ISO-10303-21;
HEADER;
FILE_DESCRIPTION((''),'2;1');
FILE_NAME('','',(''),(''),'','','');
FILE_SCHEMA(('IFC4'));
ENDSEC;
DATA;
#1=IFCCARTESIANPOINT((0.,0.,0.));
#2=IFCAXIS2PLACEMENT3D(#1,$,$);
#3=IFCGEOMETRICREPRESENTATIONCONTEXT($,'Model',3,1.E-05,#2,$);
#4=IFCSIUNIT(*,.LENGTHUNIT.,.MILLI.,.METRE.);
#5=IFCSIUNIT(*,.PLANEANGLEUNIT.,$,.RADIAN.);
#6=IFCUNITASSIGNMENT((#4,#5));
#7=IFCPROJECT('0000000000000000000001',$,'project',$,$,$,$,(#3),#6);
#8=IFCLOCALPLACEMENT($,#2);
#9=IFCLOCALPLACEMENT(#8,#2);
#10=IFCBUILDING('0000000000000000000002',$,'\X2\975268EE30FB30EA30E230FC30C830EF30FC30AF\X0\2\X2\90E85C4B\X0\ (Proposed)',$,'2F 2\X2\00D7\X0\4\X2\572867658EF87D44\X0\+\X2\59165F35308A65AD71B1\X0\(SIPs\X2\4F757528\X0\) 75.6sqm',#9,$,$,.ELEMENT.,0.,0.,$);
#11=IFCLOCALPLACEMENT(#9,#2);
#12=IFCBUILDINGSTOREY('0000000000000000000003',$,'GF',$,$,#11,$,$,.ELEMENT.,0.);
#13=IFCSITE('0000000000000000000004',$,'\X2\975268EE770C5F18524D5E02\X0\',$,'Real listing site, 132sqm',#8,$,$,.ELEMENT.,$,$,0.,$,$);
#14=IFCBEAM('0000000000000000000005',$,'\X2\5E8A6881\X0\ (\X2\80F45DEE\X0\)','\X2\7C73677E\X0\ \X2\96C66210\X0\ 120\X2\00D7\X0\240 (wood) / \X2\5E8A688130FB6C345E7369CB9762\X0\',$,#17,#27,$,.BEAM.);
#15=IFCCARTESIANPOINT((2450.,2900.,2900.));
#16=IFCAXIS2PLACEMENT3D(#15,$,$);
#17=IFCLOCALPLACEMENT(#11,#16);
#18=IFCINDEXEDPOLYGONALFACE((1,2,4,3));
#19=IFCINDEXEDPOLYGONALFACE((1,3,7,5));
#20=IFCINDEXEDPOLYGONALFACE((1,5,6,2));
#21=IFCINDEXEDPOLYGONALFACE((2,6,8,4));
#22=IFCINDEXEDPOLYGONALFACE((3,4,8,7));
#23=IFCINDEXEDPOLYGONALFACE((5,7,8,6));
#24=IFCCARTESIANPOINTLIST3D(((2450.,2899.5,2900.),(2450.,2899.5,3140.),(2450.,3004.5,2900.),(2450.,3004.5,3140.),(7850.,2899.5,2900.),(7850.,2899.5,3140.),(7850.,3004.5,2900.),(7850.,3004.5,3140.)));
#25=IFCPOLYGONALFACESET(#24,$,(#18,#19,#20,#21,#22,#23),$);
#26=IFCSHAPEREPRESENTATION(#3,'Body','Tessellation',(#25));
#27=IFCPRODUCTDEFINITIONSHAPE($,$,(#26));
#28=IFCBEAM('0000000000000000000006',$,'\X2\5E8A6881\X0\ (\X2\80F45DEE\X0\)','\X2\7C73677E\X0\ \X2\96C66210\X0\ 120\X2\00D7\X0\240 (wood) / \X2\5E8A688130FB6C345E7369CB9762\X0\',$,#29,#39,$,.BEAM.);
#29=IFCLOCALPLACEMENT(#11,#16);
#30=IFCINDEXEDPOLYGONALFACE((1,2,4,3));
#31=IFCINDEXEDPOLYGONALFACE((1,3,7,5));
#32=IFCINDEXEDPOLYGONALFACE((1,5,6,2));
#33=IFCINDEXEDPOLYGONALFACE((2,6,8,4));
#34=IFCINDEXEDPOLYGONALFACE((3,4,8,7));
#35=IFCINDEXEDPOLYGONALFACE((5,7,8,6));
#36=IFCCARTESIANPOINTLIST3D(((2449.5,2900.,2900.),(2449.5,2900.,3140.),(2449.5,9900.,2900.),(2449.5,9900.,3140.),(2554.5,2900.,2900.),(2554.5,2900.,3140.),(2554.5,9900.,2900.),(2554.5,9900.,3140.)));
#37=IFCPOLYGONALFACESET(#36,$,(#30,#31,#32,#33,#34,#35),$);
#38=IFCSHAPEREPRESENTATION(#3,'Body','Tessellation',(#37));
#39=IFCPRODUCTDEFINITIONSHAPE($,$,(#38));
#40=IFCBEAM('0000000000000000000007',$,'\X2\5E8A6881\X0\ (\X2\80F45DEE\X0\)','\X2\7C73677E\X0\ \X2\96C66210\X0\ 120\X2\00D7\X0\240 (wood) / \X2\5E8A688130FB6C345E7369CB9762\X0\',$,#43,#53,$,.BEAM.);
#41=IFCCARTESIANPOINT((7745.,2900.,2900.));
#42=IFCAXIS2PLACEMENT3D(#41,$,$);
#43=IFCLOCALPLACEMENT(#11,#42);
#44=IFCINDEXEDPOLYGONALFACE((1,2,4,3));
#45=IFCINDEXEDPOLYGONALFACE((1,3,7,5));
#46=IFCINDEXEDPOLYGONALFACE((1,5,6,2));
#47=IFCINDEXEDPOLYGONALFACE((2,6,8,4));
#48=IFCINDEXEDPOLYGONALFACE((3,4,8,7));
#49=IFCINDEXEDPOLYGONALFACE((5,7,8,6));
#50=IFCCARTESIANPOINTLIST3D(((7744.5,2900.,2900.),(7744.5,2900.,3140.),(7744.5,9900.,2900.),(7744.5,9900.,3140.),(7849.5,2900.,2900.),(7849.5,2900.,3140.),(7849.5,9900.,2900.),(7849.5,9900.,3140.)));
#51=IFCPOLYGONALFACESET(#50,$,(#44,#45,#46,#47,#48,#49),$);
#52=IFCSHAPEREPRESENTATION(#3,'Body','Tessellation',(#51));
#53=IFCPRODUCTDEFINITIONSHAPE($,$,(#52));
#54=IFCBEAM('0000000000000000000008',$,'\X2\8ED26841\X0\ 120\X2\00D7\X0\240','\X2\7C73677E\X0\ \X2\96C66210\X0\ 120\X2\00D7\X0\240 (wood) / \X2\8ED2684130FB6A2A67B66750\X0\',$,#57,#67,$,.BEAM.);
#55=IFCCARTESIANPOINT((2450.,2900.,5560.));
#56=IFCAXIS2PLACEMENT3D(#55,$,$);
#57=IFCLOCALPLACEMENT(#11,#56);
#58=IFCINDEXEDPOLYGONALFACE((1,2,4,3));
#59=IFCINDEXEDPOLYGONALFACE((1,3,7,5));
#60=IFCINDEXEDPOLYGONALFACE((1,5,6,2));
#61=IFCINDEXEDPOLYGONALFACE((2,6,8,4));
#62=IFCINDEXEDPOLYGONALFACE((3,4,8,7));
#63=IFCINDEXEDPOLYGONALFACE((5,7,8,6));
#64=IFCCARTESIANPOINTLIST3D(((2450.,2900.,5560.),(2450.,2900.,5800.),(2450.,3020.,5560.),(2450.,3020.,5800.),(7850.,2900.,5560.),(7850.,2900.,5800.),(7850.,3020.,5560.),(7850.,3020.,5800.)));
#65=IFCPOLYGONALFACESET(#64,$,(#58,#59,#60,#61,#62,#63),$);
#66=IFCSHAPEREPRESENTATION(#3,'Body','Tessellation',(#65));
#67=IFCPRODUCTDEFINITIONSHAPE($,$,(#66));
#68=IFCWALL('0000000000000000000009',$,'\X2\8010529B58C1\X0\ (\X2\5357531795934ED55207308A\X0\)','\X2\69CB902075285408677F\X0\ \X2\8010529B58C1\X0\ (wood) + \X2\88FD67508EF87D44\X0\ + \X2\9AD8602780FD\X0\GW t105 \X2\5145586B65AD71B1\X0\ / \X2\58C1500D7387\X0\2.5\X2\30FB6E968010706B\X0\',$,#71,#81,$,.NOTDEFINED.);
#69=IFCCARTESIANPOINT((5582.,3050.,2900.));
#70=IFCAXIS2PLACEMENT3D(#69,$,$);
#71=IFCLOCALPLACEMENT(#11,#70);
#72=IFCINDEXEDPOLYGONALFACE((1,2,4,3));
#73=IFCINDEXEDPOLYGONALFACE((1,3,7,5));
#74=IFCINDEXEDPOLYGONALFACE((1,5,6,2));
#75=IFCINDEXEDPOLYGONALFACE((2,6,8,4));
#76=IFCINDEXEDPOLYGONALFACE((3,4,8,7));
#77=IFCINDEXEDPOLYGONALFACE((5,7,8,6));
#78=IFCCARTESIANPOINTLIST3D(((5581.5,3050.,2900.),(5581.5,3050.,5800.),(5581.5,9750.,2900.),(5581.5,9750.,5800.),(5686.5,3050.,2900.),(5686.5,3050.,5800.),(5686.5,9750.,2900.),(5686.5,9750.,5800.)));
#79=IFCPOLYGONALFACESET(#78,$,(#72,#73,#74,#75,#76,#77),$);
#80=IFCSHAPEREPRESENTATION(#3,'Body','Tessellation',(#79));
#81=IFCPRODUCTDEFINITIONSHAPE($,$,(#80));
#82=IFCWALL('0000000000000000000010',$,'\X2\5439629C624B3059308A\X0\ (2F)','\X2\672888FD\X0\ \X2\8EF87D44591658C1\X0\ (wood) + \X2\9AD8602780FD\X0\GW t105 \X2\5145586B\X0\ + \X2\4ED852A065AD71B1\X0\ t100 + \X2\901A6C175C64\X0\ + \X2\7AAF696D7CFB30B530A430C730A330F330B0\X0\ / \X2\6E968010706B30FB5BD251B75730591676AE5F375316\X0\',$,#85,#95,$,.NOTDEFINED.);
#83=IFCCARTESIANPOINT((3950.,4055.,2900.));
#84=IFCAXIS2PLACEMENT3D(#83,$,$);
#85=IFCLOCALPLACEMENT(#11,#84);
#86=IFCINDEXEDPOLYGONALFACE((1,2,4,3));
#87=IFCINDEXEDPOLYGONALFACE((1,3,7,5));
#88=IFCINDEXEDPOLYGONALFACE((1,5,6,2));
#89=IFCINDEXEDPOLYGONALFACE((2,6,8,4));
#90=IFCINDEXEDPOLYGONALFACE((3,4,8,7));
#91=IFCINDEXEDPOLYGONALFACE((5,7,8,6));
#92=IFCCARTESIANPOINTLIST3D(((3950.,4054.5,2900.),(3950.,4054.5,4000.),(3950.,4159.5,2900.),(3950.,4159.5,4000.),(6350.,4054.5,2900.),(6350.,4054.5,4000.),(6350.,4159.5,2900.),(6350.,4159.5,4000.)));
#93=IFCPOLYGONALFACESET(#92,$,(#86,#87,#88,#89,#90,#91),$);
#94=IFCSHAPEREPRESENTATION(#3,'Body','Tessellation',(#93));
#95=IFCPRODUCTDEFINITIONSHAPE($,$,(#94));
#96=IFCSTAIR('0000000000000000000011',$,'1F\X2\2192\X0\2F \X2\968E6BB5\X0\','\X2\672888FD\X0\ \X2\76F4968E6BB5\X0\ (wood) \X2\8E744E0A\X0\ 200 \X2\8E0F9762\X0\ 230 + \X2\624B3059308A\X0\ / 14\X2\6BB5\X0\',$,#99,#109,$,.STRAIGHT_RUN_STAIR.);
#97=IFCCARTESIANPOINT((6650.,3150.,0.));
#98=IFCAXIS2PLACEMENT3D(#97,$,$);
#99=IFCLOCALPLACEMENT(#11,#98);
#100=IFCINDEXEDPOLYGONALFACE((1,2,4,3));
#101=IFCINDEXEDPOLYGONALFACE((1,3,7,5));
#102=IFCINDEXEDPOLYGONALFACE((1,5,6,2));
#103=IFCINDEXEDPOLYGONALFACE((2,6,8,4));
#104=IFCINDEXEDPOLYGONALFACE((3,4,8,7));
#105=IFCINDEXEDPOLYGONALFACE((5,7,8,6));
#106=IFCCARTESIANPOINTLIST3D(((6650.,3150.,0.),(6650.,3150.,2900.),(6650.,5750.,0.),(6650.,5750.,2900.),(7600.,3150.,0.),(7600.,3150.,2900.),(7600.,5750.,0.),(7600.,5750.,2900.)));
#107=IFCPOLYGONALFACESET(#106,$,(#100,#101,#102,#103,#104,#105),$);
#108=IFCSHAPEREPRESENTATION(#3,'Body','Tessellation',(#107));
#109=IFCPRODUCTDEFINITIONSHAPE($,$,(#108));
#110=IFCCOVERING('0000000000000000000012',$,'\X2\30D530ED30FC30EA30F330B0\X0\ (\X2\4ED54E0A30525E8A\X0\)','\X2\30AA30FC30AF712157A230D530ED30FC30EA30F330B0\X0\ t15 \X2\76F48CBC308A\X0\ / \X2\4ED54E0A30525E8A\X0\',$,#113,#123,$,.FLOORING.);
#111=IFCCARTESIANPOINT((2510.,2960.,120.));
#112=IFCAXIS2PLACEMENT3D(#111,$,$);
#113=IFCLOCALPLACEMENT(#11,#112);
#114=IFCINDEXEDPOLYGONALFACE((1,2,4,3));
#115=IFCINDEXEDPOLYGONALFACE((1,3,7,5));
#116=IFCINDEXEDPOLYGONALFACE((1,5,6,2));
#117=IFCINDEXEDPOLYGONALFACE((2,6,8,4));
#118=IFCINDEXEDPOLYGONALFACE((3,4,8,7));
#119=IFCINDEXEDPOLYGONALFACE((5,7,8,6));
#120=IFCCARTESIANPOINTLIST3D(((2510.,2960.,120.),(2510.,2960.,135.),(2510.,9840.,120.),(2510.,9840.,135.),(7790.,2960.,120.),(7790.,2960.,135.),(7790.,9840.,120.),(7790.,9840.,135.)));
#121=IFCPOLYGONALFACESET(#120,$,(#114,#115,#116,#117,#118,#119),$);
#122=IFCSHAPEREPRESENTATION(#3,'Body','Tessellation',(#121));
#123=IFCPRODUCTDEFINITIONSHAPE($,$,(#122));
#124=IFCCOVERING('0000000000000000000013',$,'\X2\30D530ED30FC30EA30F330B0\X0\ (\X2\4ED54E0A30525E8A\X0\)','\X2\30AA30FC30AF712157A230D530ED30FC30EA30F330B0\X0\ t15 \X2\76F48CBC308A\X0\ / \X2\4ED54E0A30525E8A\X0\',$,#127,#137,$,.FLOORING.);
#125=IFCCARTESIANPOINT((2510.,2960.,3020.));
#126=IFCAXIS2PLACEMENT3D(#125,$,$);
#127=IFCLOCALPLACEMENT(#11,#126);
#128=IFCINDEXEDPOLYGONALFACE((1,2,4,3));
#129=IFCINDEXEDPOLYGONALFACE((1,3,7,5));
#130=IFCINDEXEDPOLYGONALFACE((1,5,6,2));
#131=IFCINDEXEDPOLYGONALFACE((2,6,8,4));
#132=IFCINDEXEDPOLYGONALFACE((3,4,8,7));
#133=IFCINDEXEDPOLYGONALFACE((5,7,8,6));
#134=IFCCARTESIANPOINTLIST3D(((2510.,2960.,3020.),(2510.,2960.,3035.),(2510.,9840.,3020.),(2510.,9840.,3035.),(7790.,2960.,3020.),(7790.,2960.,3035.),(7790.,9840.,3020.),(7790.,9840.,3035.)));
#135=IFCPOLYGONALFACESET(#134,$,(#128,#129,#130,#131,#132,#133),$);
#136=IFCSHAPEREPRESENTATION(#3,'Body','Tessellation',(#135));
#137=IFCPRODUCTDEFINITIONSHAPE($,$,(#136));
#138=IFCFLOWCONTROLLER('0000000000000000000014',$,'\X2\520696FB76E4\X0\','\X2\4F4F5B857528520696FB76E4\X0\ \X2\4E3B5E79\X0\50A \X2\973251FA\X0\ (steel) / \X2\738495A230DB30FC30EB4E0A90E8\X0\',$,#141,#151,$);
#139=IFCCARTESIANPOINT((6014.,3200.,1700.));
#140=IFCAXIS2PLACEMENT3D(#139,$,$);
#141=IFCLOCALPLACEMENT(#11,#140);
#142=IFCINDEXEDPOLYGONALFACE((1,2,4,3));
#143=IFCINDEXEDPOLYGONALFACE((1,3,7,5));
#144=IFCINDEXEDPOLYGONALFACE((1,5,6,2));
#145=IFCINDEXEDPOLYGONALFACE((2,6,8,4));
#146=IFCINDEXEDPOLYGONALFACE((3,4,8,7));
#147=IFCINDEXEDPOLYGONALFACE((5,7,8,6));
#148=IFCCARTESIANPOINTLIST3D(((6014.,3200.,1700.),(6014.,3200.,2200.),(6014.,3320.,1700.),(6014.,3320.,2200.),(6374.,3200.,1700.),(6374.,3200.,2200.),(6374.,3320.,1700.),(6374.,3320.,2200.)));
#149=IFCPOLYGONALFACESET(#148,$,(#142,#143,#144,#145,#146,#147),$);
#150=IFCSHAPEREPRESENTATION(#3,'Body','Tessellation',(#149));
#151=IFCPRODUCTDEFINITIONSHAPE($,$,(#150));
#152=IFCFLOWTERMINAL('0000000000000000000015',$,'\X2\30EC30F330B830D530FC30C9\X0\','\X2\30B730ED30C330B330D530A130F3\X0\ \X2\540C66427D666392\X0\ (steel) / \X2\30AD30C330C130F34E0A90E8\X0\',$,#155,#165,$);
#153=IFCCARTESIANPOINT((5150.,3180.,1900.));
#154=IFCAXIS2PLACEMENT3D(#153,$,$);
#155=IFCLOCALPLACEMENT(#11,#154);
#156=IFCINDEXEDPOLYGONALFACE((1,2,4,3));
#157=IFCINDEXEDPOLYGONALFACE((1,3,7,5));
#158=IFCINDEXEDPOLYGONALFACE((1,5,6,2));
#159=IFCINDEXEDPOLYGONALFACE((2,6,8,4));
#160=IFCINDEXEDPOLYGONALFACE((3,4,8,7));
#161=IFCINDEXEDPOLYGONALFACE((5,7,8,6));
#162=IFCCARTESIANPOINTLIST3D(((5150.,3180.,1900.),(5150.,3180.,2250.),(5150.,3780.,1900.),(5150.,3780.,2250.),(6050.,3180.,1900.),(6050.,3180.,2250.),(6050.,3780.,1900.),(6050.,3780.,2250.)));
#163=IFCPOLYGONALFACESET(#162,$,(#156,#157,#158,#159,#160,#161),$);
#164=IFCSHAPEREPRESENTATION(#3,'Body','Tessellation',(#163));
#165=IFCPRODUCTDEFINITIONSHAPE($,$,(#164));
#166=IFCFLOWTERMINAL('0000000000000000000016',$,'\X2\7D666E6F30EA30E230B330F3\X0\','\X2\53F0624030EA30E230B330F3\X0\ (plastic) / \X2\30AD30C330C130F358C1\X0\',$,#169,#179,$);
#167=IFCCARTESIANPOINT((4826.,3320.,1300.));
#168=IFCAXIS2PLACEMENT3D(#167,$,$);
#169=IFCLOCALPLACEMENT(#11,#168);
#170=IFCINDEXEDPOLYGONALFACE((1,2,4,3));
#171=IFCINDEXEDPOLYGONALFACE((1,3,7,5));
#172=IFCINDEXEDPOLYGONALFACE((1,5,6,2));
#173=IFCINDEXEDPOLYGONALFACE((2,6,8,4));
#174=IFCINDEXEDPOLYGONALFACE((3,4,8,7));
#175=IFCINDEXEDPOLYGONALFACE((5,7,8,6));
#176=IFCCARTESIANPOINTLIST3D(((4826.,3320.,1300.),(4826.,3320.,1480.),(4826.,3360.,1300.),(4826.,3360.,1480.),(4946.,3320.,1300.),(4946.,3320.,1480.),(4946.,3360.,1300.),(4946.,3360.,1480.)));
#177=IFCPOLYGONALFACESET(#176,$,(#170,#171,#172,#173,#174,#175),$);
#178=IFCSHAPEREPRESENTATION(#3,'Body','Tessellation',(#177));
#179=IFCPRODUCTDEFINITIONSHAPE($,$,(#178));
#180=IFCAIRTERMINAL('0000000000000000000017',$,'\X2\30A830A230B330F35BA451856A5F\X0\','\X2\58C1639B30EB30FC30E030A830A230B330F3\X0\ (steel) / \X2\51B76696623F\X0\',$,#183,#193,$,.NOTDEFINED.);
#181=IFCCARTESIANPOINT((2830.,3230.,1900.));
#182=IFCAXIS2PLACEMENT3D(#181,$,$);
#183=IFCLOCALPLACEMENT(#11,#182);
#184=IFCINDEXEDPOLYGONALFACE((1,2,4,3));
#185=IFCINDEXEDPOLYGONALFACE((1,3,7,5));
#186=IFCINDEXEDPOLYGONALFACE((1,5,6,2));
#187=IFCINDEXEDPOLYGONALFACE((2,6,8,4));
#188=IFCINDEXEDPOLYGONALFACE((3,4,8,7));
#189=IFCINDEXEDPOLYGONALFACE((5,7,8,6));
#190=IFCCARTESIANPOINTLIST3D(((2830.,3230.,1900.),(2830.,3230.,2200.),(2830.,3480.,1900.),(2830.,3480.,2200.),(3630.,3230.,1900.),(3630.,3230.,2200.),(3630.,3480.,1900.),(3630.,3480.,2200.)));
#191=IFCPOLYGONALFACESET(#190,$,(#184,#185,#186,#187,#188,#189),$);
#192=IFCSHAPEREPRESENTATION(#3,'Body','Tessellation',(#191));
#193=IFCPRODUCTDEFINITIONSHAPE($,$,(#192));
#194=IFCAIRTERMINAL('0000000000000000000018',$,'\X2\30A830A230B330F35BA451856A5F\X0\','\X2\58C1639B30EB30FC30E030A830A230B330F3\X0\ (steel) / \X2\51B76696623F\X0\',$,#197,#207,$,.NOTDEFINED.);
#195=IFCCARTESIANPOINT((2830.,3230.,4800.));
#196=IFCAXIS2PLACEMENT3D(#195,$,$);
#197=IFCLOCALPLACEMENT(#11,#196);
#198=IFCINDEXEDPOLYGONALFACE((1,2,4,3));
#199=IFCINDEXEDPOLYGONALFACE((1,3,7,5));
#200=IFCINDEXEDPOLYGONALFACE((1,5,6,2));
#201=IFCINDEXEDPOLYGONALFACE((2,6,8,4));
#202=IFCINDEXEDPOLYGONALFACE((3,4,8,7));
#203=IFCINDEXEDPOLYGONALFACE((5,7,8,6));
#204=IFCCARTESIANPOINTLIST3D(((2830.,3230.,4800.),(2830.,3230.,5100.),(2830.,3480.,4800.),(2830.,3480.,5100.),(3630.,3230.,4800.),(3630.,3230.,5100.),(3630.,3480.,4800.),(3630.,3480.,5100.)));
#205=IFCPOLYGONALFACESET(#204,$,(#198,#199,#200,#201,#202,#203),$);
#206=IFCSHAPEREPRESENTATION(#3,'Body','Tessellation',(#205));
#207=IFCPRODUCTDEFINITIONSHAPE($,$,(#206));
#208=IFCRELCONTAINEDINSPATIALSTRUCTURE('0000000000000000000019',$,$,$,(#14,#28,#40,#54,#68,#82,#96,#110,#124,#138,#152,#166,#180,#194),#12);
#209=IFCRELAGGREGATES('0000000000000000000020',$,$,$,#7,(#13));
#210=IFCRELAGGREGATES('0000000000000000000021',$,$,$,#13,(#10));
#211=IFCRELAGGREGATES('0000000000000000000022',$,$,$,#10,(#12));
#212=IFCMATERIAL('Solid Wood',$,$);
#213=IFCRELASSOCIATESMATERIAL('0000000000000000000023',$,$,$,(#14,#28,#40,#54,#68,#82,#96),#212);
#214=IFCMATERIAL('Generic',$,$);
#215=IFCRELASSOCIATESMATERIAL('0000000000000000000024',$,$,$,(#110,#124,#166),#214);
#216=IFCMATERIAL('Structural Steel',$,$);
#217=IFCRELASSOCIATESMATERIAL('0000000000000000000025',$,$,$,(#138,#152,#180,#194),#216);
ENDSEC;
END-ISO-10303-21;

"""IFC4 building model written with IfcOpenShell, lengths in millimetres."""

from ifc_helpers import new_model, si_unit, frame, frame_2d, origin, place, context, project, spatial, rectangle, extrude, material, element, save


model = new_model("IFC4")

# Units and contexts
model_context = context("Model", 3, precision=1e-05, world=origin())
ifc_project = project(units=[si_unit("LENGTHUNIT", "METRE", prefix="MILLI"), si_unit("PLANEANGLEUNIT", "RADIAN")], contexts=[model_context])

# Site, building, storey
site_placement = place(None, origin())
site = spatial("IfcSite", under=ifc_project, at=site_placement, Name="青森県弘前市", ObjectType="Real listing site, 132sqm", CompositionType="ELEMENT", RefElevation=0.0)
building_placement = place(site_placement, origin())
building = spatial("IfcBuilding", under=site, at=building_placement, Name="青森・リモートワーク2部屋 (Proposed)", ObjectType="2F 2×4在来軸組+外張り断熱(SIPs併用) 75.6sqm", CompositionType="ELEMENT", ElevationOfRefHeight=0.0, ElevationOfTerrain=0.0)
storey_placement = place(building_placement, origin())
storey = spatial("IfcBuildingStorey", under=building, at=storey_placement, Name="GF", CompositionType="ELEMENT", Elevation=0.0)

# Shared definitions
ifc_material_1 = material(Name="Solid Wood")

# Beams
beam_1_placement = place(storey_placement, frame((2450.0, 2900.0, 2900.0)))
element("IfcBeam", 1, at=beam_1_placement, inside=storey, material=ifc_material_1, Name="床梁 (胴差)", Description="米松 集成 120×240 (wood) / 床梁・水平構面", PredefinedType="BEAM", context=model_context, shape_type="SweptSolid", body=[
    extrude(rectangle(XDim=5400.0, YDim=105.0, at=frame_2d((2700.0, 52.0))), frame((2450.0, 2900.0, 2900.0)), (0.0, 0.0, 1.0), 240.0),
])
beam_2_placement = place(storey_placement, frame((2450.0, 2900.0, 2900.0)))
element("IfcBeam", 2, at=beam_2_placement, inside=storey, material=ifc_material_1, Name="床梁 (胴差)", Description="米松 集成 120×240 (wood) / 床梁・水平構面", PredefinedType="BEAM", context=model_context, shape_type="SweptSolid", body=[
    extrude(rectangle(XDim=105.0, YDim=7000.0, at=frame_2d((52.0, 3500.0))), frame((2450.0, 2900.0, 2900.0)), (0.0, 0.0, 1.0), 240.0),
])
beam_3_placement = place(storey_placement, frame((7745.0, 2900.0, 2900.0)))
element("IfcBeam", 3, at=beam_3_placement, inside=storey, material=ifc_material_1, Name="床梁 (胴差)", Description="米松 集成 120×240 (wood) / 床梁・水平構面", PredefinedType="BEAM", context=model_context, shape_type="SweptSolid", body=[
    extrude(rectangle(XDim=105.0, YDim=7000.0, at=frame_2d((52.0, 3500.0))), frame((7745.0, 2900.0, 2900.0)), (0.0, 0.0, 1.0), 240.0),
])
beam_4_placement = place(storey_placement, frame((2450.0, 2900.0, 5560.0)))
element("IfcBeam", 4, at=beam_4_placement, inside=storey, material=ifc_material_1, Name="軒桁 120×240", Description="米松 集成 120×240 (wood) / 軒桁・横架材", PredefinedType="BEAM", context=model_context, shape_type="SweptSolid", body=[
    extrude(rectangle(XDim=5400.0, YDim=120.0, at=frame_2d((2700.0, 60.0))), frame((2450.0, 2900.0, 5560.0)), (0.0, 0.0, 1.0), 240.0),
])

# Walls
wall_1_placement = place(storey_placement, frame((5582.0, 3050.0, 2900.0)))
element("IfcWall", 5, at=wall_1_placement, inside=storey, material=ifc_material_1, Name="耐力壁 (南北間仕切り)", Description="構造用合板 耐力壁 (wood) + 製材軸組 + 高性能GW t105 充填断熱 / 壁倍率2.5・準耐火", PredefinedType="NOTDEFINED", context=model_context, shape_type="SweptSolid", body=[
    extrude(rectangle(XDim=105.0, YDim=6700.0, at=frame_2d((52.0, 3350.0))), frame((5582.0, 3050.0, 2900.0)), (0.0, 0.0, 1.0), 2900.0),
])
wall_2_placement = place(storey_placement, frame((3950.0, 4055.0, 2900.0)))
element("IfcWall", 6, at=wall_2_placement, inside=storey, material=ifc_material_1, Name="吹抜手すり (2F)", Description="木製 軸組外壁 (wood) + 高性能GW t105 充填 + 付加断熱 t100 + 通気層 + 窯業系サイディング / 準耐火・寒冷地外皮強化", PredefinedType="NOTDEFINED", context=model_context, shape_type="SweptSolid", body=[
    extrude(rectangle(XDim=2400.0, YDim=105.0, at=frame_2d((1200.0, 52.0))), frame((3950.0, 4055.0, 2900.0)), (0.0, 0.0, 1.0), 1100.0),
])

# Stair
stair_placement = place(storey_placement, frame((6650.0, 3150.0, 0.0)))
element("IfcStair", 7, at=stair_placement, inside=storey, material=ifc_material_1, Name="1F→2F 階段", Description="木製 直階段 (wood) 蹴上 200 踏面 230 + 手すり / 14段", PredefinedType="STRAIGHT_RUN_STAIR", context=model_context, shape_type="SweptSolid", body=[
    extrude(rectangle(XDim=950.0, YDim=2600.0, at=frame_2d((475.0, 1300.0))), frame((6650.0, 3150.0, 0.0)), (0.0, 0.0, 1.0), 2900.0),
])

# Coverings
ifc_material_2 = material(Name="Generic")
covering_1_placement = place(storey_placement, frame((2510.0, 2960.0, 120.0)))
element("IfcCovering", 8, at=covering_1_placement, inside=storey, material=ifc_material_2, Name="フローリング (仕上げ床)", Description="オーク無垢フローリング t15 直貼り / 仕上げ床", PredefinedType="FLOORING", context=model_context, shape_type="SweptSolid", body=[
    extrude(rectangle(XDim=5280.0, YDim=6880.0, at=frame_2d((2640.0, 3440.0))), frame((2510.0, 2960.0, 120.0)), (0.0, 0.0, 1.0), 15.0),
])
covering_2_placement = place(storey_placement, frame((2510.0, 2960.0, 3020.0)))
element("IfcCovering", 9, at=covering_2_placement, inside=storey, material=ifc_material_2, Name="フローリング (仕上げ床)", Description="オーク無垢フローリング t15 直貼り / 仕上げ床", PredefinedType="FLOORING", context=model_context, shape_type="SweptSolid", body=[
    extrude(rectangle(XDim=5280.0, YDim=6880.0, at=frame_2d((2640.0, 3440.0))), frame((2510.0, 2960.0, 3020.0)), (0.0, 0.0, 1.0), 15.0),
])

# Flow controller
ifc_material_3 = material(Name="Structural Steel")
flow_controller_placement = place(storey_placement, frame((6014.0, 3200.0, 1700.0)))
element("IfcFlowController", 10, at=flow_controller_placement, inside=storey, material=ifc_material_3, Name="分電盤", Description="住宅用分電盤 主幹50A 露出 (steel) / 玄関ホール上部", context=model_context, shape_type="SweptSolid", body=[
    extrude(rectangle(XDim=360.0, YDim=120.0, at=frame_2d((180.0, 60.0))), frame((6014.0, 3200.0, 1700.0)), (0.0, 0.0, 1.0), 500.0),
])

# Flow terminals
flow_terminal_1_placement = place(storey_placement, frame((5150.0, 3180.0, 1900.0)))
element("IfcFlowTerminal", 11, at=flow_terminal_1_placement, inside=storey, material=ifc_material_3, Name="レンジフード", Description="シロッコファン 同時給排 (steel) / キッチン上部", context=model_context, shape_type="SweptSolid", body=[
    extrude(rectangle(XDim=900.0, YDim=600.0, at=frame_2d((450.0, 300.0))), frame((5150.0, 3180.0, 1900.0)), (0.0, 0.0, 1.0), 350.0),
])
flow_terminal_2_placement = place(storey_placement, frame((4826.0, 3320.0, 1300.0)))
element("IfcFlowTerminal", 12, at=flow_terminal_2_placement, inside=storey, material=ifc_material_2, Name="給湯リモコン", Description="台所リモコン (plastic) / キッチン壁", context=model_context, shape_type="SweptSolid", body=[
    extrude(rectangle(XDim=120.0, YDim=40.0, at=frame_2d((60.0, 20.0))), frame((4826.0, 3320.0, 1300.0)), (0.0, 0.0, 1.0), 180.0),
])

# Air terminals
air_terminal_1_placement = place(storey_placement, frame((2830.0, 3230.0, 1900.0)))
element("IfcAirTerminal", 13, at=air_terminal_1_placement, inside=storey, material=ifc_material_3, Name="エアコン室内機", Description="壁掛ルームエアコン (steel) / 冷暖房", PredefinedType="NOTDEFINED", context=model_context, shape_type="SweptSolid", body=[
    extrude(rectangle(XDim=800.0, YDim=250.0, at=frame_2d((400.0, 125.0))), frame((2830.0, 3230.0, 1900.0)), (0.0, 0.0, 1.0), 300.0),
])
air_terminal_2_placement = place(storey_placement, frame((2830.0, 3230.0, 4800.0)))
element("IfcAirTerminal", 14, at=air_terminal_2_placement, inside=storey, material=ifc_material_3, Name="エアコン室内機", Description="壁掛ルームエアコン (steel) / 冷暖房", PredefinedType="NOTDEFINED", context=model_context, shape_type="SweptSolid", body=[
    extrude(rectangle(XDim=800.0, YDim=250.0, at=frame_2d((400.0, 125.0))), frame((2830.0, 3230.0, 4800.0)), (0.0, 0.0, 1.0), 300.0),
])

save(model, "model.ifc")
